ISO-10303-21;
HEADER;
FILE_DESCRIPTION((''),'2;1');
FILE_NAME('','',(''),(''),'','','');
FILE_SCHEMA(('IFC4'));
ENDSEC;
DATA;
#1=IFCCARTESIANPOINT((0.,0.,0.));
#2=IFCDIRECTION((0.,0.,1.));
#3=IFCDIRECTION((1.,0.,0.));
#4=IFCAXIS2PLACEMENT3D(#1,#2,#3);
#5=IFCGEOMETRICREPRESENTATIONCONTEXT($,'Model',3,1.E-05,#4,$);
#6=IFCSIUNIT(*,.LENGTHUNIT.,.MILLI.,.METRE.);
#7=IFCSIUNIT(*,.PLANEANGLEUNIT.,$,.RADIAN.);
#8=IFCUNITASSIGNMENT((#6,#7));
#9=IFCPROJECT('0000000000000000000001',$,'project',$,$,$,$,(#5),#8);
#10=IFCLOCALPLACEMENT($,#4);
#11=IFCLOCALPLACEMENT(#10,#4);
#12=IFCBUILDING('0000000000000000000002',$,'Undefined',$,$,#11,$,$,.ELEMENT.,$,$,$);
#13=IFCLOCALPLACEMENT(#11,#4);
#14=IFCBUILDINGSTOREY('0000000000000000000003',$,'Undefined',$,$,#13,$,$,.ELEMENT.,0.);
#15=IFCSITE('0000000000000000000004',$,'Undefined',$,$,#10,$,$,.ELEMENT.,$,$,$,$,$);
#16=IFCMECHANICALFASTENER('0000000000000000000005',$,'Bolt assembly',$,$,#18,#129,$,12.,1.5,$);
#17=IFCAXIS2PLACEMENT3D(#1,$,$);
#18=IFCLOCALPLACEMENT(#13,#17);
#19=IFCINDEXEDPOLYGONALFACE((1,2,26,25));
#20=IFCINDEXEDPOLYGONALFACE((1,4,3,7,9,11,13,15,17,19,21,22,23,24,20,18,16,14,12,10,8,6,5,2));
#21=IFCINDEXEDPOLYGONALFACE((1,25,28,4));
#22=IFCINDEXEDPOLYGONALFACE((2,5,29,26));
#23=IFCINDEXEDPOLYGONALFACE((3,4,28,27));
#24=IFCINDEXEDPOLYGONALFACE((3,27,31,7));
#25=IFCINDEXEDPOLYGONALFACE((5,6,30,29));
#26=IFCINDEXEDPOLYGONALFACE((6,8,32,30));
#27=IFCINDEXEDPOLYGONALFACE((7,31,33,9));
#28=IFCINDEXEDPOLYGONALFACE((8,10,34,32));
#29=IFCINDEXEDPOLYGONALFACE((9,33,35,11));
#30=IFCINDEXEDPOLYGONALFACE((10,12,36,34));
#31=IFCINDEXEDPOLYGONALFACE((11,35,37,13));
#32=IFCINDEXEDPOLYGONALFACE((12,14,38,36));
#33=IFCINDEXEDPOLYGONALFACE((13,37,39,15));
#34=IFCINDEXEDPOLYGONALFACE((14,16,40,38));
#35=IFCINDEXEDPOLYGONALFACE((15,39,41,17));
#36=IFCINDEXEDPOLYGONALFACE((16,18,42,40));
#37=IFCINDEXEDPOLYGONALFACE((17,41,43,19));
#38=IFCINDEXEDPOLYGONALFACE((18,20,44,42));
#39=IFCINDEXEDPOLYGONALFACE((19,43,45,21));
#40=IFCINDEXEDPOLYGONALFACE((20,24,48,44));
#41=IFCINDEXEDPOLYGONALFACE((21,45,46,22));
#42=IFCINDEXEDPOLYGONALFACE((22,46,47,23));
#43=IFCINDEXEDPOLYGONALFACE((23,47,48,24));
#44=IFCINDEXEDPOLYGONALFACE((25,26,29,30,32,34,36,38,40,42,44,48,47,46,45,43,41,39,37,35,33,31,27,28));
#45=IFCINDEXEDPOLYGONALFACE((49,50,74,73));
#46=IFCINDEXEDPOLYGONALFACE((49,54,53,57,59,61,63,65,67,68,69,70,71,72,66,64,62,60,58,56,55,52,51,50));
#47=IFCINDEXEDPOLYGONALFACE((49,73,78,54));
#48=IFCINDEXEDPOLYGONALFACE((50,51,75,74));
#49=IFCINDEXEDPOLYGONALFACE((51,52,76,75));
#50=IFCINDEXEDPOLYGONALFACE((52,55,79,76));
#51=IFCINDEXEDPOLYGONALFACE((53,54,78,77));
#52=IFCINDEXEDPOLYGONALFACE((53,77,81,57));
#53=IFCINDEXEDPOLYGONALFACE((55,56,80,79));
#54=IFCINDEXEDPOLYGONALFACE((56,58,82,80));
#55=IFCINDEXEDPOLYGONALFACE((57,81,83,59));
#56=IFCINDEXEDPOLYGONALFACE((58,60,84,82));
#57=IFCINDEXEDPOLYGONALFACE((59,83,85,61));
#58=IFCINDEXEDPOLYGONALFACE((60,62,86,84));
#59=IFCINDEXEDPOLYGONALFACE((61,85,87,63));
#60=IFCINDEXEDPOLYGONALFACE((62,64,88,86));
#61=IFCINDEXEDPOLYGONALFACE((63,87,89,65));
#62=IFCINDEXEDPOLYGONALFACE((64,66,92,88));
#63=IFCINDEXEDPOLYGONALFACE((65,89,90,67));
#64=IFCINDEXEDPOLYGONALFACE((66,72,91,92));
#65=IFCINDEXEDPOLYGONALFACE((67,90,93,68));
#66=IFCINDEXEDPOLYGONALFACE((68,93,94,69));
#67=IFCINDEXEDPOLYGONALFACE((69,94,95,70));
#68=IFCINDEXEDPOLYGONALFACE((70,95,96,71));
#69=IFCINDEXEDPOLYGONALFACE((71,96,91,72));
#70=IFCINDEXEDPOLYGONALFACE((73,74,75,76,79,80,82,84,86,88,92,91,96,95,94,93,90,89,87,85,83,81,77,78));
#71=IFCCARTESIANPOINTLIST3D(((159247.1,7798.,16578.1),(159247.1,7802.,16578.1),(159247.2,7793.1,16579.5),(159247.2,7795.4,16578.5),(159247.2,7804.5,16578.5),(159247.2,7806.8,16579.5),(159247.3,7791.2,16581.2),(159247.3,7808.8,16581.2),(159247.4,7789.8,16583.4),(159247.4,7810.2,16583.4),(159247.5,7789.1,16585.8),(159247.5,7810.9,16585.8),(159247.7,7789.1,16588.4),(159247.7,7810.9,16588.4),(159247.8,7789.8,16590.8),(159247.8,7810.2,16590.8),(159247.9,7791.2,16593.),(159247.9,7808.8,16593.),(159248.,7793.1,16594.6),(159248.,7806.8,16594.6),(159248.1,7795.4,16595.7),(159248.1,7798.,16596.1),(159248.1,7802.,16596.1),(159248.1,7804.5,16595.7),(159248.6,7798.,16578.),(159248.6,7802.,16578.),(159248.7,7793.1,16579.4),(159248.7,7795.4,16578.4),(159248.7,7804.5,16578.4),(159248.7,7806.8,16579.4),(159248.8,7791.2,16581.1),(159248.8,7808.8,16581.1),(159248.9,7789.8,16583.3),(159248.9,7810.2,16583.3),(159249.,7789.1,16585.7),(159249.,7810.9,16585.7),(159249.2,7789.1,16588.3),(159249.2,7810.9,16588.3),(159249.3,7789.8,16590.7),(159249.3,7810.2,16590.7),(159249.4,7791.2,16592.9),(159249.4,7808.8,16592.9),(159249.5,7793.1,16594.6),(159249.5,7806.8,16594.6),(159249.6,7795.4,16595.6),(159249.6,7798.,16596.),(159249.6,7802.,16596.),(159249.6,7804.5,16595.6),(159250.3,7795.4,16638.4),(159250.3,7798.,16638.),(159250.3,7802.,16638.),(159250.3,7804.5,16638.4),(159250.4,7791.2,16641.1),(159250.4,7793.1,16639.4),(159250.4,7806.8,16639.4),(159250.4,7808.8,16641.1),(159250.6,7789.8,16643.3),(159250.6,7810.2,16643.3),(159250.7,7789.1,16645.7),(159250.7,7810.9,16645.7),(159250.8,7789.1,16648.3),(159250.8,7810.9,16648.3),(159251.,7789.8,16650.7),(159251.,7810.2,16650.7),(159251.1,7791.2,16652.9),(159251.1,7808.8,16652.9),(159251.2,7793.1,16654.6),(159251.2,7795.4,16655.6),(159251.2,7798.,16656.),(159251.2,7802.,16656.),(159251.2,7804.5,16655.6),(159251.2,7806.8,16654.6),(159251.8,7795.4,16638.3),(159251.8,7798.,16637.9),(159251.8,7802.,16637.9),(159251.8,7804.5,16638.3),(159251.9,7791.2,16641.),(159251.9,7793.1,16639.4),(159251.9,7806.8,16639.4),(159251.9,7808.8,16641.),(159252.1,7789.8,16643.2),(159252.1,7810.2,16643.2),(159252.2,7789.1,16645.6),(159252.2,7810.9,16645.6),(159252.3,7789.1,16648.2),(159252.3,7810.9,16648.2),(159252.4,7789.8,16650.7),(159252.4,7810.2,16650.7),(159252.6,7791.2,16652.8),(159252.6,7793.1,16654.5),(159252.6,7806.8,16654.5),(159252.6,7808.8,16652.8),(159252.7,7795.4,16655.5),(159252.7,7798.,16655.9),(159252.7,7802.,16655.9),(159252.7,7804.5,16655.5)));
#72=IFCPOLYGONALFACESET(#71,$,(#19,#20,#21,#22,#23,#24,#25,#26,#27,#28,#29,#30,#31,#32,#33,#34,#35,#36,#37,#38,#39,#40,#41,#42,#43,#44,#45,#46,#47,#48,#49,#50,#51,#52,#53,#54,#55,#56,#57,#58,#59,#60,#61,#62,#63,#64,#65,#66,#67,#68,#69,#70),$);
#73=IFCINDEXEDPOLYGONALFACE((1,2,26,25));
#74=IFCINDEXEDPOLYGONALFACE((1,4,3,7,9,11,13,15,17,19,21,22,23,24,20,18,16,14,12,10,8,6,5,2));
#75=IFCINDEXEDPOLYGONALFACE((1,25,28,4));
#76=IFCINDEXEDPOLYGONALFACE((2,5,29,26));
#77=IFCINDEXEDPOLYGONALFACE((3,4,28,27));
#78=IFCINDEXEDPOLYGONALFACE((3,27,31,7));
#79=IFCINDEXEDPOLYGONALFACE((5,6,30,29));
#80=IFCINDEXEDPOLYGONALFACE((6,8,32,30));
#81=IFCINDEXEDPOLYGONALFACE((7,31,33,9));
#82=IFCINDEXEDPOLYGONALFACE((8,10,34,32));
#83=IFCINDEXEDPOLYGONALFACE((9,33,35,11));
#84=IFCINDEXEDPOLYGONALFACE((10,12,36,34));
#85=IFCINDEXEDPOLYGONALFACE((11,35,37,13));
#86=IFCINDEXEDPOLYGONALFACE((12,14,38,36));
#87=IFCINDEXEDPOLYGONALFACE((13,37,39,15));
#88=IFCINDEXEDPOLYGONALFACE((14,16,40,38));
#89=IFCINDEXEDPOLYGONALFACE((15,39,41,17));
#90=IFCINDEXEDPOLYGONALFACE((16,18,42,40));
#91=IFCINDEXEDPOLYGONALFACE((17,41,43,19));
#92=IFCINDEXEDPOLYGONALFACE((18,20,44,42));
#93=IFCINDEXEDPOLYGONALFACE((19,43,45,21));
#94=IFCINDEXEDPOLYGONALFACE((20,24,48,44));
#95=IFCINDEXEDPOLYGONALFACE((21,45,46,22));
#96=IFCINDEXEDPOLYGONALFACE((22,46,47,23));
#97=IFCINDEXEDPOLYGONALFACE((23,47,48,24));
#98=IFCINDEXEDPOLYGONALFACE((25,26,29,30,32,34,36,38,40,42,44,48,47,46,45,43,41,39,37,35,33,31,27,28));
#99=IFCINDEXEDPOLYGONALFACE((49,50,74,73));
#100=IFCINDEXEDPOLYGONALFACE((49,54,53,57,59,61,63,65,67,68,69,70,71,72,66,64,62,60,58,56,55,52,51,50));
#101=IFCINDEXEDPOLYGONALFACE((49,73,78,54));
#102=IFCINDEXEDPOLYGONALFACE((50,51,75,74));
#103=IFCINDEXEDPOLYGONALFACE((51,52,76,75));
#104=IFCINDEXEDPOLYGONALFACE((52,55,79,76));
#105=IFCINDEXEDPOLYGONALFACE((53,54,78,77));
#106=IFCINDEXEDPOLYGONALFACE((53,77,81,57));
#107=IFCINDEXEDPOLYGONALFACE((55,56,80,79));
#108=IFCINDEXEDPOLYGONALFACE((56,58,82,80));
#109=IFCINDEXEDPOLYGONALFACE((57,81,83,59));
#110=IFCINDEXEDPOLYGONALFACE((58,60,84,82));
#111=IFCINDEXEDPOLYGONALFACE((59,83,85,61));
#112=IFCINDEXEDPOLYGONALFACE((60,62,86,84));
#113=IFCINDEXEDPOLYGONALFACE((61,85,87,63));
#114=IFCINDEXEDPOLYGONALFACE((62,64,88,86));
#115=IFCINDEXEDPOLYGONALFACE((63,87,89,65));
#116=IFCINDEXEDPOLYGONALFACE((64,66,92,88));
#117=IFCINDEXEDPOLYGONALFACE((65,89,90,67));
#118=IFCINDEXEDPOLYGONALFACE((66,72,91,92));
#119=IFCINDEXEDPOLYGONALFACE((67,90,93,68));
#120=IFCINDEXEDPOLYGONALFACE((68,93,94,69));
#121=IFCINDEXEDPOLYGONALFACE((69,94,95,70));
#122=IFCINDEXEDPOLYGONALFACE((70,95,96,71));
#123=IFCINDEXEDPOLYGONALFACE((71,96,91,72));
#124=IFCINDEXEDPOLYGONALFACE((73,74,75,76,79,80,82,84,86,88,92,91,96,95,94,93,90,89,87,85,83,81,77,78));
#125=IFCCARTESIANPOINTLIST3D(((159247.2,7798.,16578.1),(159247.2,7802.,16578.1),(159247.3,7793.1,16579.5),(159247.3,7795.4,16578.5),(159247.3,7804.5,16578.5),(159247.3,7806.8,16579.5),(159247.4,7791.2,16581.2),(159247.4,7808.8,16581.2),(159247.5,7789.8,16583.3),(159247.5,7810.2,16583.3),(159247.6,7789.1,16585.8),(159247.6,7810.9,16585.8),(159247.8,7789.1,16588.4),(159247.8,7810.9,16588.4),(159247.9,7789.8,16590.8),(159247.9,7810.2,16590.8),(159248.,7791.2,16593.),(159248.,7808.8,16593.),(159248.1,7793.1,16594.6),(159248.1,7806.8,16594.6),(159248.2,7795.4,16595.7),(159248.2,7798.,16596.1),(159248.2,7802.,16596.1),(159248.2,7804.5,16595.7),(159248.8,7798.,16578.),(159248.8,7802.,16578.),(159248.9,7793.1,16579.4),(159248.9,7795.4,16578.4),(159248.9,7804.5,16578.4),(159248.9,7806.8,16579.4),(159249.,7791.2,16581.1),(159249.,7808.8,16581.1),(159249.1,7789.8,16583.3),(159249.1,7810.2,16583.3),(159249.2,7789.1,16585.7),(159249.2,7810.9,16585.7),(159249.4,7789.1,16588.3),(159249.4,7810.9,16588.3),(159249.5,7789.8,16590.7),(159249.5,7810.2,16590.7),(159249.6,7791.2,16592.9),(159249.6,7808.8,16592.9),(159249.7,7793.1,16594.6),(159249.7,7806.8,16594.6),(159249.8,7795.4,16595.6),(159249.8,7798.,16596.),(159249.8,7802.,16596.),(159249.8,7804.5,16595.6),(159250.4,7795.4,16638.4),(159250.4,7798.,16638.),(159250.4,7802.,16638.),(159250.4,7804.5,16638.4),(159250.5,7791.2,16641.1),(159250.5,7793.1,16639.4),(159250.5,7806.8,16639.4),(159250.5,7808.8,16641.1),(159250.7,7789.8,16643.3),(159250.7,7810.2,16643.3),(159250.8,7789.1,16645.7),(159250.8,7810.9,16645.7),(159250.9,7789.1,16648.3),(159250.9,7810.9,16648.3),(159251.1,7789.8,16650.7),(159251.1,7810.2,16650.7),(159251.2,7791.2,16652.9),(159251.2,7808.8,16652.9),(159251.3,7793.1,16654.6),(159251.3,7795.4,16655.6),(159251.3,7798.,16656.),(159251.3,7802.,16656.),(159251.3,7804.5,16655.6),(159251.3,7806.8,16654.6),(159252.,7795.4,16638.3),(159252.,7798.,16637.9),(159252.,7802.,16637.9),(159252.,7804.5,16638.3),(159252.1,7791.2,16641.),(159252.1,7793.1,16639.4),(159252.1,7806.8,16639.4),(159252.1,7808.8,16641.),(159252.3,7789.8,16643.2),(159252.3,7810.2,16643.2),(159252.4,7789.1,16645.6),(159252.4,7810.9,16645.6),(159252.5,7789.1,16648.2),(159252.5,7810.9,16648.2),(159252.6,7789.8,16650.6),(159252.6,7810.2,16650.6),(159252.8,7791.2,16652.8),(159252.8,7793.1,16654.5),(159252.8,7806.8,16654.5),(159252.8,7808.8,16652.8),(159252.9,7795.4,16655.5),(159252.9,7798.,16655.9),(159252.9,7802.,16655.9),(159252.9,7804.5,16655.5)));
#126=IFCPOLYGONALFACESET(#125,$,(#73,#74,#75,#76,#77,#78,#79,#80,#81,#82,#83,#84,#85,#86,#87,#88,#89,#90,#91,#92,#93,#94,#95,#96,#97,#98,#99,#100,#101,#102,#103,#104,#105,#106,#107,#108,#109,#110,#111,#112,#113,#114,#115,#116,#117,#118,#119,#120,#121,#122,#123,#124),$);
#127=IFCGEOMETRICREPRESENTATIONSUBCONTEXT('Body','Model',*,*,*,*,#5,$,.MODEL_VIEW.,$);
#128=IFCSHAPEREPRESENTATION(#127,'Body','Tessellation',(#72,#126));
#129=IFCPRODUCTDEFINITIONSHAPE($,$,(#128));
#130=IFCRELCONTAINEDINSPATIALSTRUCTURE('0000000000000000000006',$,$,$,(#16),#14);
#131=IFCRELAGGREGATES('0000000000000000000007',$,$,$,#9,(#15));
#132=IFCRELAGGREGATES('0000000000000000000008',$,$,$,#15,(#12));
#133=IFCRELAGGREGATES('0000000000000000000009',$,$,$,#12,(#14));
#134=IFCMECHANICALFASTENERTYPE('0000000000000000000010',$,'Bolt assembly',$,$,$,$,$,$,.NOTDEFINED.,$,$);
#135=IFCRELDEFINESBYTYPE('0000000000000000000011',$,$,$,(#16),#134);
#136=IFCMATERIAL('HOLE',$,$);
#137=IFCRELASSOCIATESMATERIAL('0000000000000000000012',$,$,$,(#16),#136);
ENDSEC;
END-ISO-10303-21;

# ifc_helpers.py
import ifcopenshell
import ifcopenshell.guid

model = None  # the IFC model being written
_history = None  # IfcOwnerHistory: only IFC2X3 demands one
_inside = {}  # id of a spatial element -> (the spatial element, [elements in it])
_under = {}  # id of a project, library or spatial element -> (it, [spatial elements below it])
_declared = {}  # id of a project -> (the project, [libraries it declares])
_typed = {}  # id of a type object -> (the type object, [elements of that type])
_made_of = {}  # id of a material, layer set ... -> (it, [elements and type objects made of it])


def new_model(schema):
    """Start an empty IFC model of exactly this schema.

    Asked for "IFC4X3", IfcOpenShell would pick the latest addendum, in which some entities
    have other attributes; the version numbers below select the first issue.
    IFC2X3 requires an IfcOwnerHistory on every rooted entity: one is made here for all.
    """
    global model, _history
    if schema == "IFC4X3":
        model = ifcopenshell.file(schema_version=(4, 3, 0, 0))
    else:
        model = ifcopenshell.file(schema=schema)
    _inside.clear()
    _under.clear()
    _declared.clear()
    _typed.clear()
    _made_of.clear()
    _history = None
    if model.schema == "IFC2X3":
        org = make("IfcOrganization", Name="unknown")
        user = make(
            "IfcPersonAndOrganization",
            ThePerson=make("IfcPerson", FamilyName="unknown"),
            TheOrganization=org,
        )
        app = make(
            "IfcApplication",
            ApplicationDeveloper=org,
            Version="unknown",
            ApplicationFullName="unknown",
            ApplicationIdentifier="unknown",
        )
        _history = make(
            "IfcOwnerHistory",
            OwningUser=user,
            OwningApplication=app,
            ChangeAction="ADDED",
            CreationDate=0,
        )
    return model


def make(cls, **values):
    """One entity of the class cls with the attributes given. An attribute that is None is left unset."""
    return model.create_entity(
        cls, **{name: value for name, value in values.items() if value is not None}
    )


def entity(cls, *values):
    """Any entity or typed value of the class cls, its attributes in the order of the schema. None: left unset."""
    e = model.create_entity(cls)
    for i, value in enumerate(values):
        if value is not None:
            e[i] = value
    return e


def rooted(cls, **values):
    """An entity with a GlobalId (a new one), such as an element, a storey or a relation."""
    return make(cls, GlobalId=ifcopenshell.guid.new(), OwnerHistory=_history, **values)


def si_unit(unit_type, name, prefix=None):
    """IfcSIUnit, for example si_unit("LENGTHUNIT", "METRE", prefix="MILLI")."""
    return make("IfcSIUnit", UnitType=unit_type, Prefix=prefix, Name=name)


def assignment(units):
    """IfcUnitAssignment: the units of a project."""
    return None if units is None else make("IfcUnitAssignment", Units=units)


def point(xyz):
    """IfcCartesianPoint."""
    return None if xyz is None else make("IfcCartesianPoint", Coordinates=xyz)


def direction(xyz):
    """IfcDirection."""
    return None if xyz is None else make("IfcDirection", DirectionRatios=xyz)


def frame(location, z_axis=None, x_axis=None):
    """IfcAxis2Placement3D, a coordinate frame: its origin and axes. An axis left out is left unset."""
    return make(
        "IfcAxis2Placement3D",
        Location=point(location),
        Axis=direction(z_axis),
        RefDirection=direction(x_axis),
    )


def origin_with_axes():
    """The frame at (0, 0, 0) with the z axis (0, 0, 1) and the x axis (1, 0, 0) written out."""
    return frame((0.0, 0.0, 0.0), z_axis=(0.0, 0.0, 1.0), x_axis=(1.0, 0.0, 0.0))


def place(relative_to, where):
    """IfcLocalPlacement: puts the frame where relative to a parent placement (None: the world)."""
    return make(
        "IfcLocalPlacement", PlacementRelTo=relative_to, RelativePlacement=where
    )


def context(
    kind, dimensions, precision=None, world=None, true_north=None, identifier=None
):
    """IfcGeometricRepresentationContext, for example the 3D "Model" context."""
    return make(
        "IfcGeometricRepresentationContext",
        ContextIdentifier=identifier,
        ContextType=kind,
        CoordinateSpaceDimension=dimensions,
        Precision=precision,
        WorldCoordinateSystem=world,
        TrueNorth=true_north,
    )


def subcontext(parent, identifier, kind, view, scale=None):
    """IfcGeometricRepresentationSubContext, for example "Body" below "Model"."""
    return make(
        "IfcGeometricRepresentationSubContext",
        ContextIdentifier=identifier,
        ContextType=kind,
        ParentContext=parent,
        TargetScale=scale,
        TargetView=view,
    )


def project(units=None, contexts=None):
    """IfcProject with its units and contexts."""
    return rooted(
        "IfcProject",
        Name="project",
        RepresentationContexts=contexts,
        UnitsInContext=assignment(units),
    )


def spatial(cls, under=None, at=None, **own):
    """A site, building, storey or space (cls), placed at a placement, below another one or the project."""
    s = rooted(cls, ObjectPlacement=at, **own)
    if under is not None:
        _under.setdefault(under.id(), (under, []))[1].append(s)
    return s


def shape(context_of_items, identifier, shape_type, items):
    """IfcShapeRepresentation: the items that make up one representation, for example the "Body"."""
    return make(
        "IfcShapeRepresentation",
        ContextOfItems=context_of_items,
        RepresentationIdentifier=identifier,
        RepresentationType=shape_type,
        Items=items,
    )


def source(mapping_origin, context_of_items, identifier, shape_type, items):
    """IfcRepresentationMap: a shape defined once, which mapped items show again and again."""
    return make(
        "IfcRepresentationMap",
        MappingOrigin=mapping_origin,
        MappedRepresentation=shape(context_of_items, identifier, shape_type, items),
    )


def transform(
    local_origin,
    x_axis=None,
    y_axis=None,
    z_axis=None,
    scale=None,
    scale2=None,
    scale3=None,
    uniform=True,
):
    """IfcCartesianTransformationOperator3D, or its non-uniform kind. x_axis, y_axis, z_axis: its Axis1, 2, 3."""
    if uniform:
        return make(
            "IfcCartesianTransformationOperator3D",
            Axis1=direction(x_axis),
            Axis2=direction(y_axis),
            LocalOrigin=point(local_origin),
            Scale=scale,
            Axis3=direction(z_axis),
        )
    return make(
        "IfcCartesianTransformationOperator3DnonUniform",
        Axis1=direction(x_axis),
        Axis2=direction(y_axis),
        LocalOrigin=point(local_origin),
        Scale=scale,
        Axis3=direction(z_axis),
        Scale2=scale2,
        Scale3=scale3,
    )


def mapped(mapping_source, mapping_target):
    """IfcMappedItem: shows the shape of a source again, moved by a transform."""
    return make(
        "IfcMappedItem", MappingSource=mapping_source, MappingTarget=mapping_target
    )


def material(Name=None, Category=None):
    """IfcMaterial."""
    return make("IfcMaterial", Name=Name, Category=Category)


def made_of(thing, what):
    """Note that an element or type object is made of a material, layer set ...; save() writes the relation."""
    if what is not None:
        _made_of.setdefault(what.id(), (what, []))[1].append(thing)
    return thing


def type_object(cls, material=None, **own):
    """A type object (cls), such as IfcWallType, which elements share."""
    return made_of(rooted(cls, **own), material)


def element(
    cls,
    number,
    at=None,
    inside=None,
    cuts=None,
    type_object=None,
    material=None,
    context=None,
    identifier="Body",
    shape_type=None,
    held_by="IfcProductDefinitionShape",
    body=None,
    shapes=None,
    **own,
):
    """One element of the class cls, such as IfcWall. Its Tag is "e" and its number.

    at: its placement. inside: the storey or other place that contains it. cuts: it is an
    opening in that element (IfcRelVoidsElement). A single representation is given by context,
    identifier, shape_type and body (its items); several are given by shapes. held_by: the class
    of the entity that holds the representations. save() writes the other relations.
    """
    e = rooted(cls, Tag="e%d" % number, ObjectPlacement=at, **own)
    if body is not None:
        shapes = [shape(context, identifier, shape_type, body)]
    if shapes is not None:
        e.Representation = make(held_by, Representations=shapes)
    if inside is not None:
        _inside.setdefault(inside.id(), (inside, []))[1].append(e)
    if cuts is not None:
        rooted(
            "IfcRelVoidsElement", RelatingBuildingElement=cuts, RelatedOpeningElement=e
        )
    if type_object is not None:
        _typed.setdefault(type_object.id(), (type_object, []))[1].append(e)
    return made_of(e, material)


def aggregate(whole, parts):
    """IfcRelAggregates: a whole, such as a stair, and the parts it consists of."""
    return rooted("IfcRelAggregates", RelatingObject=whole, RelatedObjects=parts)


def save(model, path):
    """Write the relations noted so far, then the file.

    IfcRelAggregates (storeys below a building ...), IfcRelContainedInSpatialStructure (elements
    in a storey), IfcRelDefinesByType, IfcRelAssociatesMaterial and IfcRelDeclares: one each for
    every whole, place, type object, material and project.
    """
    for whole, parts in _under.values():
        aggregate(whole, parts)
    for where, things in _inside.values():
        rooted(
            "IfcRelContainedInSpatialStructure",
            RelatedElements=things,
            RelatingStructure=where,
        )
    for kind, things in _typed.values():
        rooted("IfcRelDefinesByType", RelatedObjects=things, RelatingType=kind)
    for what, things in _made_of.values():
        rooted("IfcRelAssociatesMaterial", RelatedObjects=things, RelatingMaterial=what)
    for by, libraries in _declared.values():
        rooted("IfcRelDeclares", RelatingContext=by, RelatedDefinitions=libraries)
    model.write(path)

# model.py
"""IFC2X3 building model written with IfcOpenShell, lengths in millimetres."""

from ifc_helpers import new_model, entity, si_unit, frame, origin_with_axes, place, context, subcontext, project, spatial, source, transform, mapped, material, type_object, element, save


model = new_model("IFC2X3")

# Units and contexts
model_context = context("Model", 3, precision=1e-05, world=origin_with_axes())
body_context = subcontext(model_context, "Body", "Model", "MODEL_VIEW")
ifc_project = project(units=[si_unit("LENGTHUNIT", "METRE", prefix="MILLI"), si_unit("PLANEANGLEUNIT", "RADIAN")], contexts=[model_context])

# Site, building, storey
site_placement = place(None, origin_with_axes())
site = spatial("IfcSite", under=ifc_project, at=site_placement, Name="Undefined", CompositionType="ELEMENT")
building_placement = place(site_placement, origin_with_axes())
building = spatial("IfcBuilding", under=site, at=building_placement, Name="Undefined", CompositionType="ELEMENT")
storey_placement = place(building_placement, origin_with_axes())
storey = spatial("IfcBuildingStorey", under=building, at=storey_placement, Name="Undefined", CompositionType="ELEMENT", Elevation=0.0)

# Mechanical fastener
ifc_material_1 = material(Name="HOLE")
mechanical_fastener_type = type_object("IfcMechanicalFastenerType", Name="Bolt assembly")
shared_circle_1 = entity("IfcCircle", entity("IfcAxis2Placement2D", entity("IfcCartesianPoint", [0.0, -2.0]), entity("IfcDirection", [1.0, 0.0])), 9.0)
shared_circle_2 = entity("IfcCircle", entity("IfcAxis2Placement2D", entity("IfcCartesianPoint", [0.0, 2.0]), entity("IfcDirection", [-1.0, 0.0])), 9.0)
shared_composite_curve = entity("IfcCompositeCurve", [entity("IfcCompositeCurveSegment", "CONTINUOUS", True, entity("IfcPolyline", [entity("IfcCartesianPoint", [9.0, 2.0]), entity("IfcCartesianPoint", [9.0, -2.0])])), entity("IfcCompositeCurveSegment", "CONTINUOUS", True, entity("IfcTrimmedCurve", shared_circle_1, [entity("IfcParameterValue", 0.0)], [entity("IfcParameterValue", 3.141593)], False, "PARAMETER")), entity("IfcCompositeCurveSegment", "CONTINUOUS", True, entity("IfcPolyline", [entity("IfcCartesianPoint", [-9.0, -2.0]), entity("IfcCartesianPoint", [-9.0, 2.0])])), entity("IfcCompositeCurveSegment", "DISCONTINUOUS", True, entity("IfcTrimmedCurve", shared_circle_2, [entity("IfcParameterValue", 0.0)], [entity("IfcParameterValue", 3.141593)], False, "PARAMETER"))], False)
shared_shape_1 = source(origin_with_axes(), body_context, "Body", "SweptSolid", [
    entity("IfcExtrudedAreaSolid", entity("IfcArbitraryClosedProfileDef", "AREA", None, shared_composite_curve), entity("IfcAxis2Placement3D", entity("IfcCartesianPoint", [0.0, 0.1, 0.0]), entity("IfcDirection", [0.0, 1.0, 0.0]), entity("IfcDirection", [1.0, 0.0, 0.0])), entity("IfcDirection", [0.0, 0.0, 1.0]), 1.5),
    entity("IfcExtrudedAreaSolid", entity("IfcArbitraryClosedProfileDef", "AREA", None, shared_composite_curve), entity("IfcAxis2Placement3D", entity("IfcCartesianPoint", [0.0, -0.1, 0.0]), entity("IfcDirection", [0.0, 1.0, 0.0]), entity("IfcDirection", [1.0, 0.0, 0.0])), entity("IfcDirection", [0.0, 0.0, 1.0]), 1.6),
])
mechanical_fastener_1_placement = place(storey_placement, frame((159252.4, 7800.0, 16646.9), z_axis=(0.0, 1.0, 0.0), x_axis=(-0.052392, 0.0, -0.998627)))
element("IfcMechanicalFastener", 1, at=mechanical_fastener_1_placement, inside=storey, type_object=mechanical_fastener_type, material=ifc_material_1, Name="Bolt assembly", NominalDiameter=12.0, NominalLength=1.5, context=body_context, shape_type="MappedRepresentation", body=[
    mapped(shared_shape_1, transform((0.0, 0.0, 0.0))),
    mapped(shared_shape_1, transform((60.0, 0.0, 0.0))),
])

save(model, "model.ifc")
